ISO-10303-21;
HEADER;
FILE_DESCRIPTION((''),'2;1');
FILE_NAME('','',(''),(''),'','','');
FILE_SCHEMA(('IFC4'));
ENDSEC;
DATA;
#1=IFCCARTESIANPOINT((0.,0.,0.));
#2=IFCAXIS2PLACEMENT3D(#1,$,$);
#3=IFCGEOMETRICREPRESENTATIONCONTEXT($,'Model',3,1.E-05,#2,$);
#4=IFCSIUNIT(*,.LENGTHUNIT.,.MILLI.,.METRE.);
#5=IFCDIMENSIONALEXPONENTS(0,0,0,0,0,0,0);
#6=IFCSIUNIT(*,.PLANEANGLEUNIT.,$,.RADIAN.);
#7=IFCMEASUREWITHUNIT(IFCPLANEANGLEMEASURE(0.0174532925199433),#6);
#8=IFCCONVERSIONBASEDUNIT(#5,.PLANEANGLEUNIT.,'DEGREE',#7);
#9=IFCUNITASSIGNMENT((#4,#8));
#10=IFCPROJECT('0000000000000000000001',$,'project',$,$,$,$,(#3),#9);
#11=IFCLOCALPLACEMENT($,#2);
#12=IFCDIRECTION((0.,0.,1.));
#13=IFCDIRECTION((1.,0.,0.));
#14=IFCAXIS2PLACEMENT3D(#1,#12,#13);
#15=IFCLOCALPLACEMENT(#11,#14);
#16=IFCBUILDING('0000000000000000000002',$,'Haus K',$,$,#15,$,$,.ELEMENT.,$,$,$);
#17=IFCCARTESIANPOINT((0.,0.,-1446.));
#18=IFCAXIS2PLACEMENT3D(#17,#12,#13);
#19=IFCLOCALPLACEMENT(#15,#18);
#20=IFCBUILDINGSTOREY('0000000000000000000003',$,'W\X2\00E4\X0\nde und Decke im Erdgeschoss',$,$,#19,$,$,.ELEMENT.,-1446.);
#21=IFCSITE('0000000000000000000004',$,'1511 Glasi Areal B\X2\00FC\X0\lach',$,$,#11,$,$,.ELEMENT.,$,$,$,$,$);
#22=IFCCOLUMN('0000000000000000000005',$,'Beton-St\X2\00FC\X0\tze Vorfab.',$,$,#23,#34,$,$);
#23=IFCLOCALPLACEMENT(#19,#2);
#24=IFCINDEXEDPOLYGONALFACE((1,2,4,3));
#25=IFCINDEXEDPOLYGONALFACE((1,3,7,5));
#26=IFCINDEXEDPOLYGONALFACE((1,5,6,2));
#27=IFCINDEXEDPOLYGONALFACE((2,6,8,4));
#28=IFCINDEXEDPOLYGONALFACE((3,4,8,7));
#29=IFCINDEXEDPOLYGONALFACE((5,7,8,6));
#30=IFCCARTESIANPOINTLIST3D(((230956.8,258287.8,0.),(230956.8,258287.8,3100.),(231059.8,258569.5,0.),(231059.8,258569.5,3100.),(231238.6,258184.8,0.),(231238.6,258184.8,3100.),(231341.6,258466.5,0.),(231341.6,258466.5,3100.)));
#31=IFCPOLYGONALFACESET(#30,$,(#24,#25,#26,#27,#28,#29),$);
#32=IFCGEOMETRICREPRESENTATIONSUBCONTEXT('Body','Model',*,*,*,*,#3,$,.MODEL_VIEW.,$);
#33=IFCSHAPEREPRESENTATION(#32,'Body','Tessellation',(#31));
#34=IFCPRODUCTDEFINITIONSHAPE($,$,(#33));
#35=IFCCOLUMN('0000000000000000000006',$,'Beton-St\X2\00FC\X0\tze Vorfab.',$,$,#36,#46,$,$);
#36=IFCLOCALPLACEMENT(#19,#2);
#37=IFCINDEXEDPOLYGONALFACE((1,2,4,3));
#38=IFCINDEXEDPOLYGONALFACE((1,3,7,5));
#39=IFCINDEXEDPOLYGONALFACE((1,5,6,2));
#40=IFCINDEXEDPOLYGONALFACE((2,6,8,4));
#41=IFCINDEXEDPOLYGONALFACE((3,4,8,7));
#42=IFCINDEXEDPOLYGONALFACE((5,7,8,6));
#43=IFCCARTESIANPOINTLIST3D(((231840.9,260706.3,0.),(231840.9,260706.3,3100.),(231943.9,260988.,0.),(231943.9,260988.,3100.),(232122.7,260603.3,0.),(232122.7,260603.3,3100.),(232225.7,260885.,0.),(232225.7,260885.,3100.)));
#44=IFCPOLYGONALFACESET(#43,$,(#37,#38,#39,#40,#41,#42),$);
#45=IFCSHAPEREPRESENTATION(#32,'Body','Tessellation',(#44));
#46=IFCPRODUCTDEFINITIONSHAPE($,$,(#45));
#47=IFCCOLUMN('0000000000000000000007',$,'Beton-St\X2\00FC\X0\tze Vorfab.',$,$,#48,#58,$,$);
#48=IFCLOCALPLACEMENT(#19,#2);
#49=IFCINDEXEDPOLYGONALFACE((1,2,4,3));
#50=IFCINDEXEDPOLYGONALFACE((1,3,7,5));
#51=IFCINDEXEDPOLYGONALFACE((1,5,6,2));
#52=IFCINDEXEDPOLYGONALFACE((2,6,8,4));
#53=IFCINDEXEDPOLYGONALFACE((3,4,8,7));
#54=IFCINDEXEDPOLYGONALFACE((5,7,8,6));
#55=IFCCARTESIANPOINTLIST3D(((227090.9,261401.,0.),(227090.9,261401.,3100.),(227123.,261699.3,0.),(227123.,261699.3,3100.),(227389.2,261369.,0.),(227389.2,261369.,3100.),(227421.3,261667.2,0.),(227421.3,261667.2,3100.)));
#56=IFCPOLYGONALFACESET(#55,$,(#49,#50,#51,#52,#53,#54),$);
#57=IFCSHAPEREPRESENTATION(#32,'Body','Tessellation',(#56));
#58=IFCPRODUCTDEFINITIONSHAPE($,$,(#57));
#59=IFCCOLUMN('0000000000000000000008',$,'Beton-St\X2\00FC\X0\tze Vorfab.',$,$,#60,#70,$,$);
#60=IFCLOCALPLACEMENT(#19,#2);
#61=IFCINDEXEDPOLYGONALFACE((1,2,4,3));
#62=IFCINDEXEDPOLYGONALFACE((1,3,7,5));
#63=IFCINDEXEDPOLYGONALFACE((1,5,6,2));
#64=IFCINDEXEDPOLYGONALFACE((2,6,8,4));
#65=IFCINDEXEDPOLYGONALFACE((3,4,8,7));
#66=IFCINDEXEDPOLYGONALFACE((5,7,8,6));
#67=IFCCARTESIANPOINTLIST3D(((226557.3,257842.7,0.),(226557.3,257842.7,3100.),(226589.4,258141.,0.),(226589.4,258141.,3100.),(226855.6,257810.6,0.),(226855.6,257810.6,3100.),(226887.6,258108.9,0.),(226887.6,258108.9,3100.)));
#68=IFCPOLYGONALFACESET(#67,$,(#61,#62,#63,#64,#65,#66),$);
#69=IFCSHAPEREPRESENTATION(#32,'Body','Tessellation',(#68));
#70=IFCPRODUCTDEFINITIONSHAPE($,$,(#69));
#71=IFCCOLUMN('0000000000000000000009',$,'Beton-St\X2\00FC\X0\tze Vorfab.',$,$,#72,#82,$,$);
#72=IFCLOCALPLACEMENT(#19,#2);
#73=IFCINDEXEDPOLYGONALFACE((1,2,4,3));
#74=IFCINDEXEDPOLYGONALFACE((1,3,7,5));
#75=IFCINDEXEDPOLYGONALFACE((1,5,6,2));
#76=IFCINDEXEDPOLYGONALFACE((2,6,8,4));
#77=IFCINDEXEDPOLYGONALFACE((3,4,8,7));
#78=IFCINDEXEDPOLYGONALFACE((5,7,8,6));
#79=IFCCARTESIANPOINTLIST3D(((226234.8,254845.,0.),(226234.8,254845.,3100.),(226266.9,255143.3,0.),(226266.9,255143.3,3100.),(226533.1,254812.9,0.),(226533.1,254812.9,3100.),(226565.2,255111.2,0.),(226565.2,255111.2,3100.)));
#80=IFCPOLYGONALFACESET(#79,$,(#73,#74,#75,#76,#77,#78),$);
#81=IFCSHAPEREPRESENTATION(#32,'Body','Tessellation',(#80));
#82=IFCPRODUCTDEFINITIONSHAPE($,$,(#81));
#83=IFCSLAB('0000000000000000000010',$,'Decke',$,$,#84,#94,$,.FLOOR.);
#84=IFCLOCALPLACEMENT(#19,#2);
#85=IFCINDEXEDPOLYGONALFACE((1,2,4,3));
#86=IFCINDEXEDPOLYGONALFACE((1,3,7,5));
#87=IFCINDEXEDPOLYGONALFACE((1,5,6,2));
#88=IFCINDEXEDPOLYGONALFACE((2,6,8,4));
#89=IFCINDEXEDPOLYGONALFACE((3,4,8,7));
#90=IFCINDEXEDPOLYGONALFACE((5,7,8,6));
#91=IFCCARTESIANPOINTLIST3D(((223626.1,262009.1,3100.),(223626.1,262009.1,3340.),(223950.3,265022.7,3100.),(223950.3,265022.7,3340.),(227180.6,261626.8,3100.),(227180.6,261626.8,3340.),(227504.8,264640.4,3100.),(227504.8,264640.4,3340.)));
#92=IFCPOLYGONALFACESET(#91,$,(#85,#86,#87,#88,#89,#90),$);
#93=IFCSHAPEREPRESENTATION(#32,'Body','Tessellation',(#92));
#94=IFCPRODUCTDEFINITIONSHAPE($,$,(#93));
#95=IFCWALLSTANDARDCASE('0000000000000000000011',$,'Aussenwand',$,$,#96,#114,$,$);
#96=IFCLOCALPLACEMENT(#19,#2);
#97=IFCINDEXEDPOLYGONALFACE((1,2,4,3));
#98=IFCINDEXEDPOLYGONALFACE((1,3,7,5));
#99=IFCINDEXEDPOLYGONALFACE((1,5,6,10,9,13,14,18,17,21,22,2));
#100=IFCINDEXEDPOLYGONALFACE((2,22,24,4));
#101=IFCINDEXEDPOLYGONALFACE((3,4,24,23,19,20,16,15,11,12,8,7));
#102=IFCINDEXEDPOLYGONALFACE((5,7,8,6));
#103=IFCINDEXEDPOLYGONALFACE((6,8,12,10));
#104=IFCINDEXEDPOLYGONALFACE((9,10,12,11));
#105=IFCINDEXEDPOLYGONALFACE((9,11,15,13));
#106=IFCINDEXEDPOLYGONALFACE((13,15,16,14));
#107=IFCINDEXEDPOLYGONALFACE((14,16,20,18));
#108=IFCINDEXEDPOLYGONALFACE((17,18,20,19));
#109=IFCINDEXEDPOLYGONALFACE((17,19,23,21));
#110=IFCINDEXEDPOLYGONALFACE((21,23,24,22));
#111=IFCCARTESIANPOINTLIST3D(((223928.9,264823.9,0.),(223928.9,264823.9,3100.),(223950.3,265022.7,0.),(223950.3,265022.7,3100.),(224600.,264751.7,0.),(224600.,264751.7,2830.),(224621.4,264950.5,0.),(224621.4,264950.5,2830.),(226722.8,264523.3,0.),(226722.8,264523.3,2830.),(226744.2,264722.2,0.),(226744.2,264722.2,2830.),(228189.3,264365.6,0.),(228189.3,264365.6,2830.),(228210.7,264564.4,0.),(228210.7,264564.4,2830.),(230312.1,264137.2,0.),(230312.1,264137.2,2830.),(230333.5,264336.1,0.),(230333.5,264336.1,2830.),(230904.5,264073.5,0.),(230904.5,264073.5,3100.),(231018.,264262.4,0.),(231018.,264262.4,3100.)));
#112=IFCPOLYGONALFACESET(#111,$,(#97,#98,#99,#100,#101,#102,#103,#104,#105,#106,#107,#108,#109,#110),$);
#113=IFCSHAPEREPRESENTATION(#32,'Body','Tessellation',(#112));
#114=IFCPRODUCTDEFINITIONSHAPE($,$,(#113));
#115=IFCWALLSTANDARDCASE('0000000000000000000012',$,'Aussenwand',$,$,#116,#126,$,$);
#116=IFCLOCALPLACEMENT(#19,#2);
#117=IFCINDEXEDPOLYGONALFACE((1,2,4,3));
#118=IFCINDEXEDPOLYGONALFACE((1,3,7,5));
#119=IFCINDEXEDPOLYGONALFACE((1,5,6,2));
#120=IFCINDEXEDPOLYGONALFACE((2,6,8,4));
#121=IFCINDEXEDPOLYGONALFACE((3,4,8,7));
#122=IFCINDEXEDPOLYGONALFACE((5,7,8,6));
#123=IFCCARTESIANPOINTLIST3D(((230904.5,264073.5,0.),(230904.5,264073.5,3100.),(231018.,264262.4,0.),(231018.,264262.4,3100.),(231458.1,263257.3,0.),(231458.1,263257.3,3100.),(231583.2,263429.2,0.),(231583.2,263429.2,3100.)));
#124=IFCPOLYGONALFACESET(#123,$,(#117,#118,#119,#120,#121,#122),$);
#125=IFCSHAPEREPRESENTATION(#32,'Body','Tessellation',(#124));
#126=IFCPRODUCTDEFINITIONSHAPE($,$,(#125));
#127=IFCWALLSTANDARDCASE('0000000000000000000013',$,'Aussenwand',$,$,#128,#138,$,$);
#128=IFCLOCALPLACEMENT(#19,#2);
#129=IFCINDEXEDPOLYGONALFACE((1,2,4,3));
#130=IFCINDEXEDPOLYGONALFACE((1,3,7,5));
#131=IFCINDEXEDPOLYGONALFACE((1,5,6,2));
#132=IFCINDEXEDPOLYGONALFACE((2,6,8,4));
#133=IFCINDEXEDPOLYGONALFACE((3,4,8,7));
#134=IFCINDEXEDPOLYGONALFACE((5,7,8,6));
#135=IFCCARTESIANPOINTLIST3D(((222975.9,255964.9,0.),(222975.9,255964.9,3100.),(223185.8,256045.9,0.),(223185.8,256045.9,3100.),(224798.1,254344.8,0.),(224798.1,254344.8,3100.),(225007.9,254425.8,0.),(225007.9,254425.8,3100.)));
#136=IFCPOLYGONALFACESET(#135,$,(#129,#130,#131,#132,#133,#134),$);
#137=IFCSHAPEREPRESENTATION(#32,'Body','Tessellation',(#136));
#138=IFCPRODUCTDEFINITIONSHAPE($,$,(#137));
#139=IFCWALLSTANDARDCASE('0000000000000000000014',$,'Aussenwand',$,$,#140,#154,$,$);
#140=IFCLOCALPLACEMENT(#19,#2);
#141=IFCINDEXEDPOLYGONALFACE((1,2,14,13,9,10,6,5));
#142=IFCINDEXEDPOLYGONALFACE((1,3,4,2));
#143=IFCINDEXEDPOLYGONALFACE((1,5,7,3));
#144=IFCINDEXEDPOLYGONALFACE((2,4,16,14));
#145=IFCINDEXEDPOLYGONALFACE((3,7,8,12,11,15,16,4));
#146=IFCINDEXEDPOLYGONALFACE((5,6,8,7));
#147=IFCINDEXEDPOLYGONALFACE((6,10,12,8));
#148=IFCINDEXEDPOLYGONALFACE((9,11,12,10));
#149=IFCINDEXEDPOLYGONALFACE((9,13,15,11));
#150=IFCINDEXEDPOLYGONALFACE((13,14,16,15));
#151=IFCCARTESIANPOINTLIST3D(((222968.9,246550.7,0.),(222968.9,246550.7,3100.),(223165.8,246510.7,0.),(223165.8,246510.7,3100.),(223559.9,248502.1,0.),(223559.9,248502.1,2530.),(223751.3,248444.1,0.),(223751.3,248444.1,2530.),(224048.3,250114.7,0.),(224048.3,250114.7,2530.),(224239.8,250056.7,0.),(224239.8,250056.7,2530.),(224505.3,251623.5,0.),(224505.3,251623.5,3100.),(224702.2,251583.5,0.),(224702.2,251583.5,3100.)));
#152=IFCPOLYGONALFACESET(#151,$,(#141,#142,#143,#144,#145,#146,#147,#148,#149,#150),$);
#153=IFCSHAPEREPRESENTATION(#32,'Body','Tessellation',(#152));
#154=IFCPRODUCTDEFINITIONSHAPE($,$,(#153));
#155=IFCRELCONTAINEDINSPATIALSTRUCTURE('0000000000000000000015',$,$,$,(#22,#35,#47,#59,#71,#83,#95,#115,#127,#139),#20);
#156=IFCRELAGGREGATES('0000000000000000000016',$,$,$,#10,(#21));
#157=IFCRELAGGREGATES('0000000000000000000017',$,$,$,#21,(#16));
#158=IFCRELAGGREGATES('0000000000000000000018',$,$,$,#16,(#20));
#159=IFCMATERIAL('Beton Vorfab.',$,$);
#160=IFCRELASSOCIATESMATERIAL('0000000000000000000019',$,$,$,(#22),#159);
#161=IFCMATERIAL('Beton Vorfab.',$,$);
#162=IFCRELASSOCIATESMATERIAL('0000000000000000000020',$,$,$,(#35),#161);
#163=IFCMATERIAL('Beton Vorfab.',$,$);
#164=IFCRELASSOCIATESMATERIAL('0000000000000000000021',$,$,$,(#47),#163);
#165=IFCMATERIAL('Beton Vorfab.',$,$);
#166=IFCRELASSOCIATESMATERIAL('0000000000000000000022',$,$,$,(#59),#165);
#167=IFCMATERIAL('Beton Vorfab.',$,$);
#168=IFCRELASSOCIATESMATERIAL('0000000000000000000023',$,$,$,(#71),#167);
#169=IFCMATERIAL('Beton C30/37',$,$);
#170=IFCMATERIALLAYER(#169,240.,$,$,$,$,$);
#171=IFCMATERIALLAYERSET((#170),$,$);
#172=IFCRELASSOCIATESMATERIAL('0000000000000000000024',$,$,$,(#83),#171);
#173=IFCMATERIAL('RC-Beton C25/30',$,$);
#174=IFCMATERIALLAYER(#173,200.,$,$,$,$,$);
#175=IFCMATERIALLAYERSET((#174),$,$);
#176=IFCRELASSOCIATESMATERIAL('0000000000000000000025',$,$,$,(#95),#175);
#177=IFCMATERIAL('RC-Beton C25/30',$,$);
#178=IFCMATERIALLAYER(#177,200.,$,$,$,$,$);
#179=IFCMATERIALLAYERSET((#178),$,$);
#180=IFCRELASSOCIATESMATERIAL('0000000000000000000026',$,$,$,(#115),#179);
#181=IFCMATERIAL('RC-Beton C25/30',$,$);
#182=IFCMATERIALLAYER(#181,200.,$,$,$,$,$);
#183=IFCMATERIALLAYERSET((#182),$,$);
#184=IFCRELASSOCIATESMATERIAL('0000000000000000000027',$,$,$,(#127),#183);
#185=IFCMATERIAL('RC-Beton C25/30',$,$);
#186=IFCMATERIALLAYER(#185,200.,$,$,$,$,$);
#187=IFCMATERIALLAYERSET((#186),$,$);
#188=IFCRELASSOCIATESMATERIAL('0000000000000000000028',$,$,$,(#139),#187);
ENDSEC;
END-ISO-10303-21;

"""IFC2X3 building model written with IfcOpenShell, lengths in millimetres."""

from ifc_helpers import new_model, entity, si_unit, converted_unit, frame, frame_2d, origin, origin_with_axes, place, context, subcontext, project, spatial, polyline, rectangle, outline, extrude, material, layer, layer_set, layer_usage, element, save


model = new_model("IFC2X3")

# Units and contexts
model_context = context("Model", 3, precision=1e-05, world=origin())
body_context = subcontext(model_context, "Body", "Model", "MODEL_VIEW")
ifc_project = project(units=[si_unit("LENGTHUNIT", "METRE", prefix="MILLI"), converted_unit("PLANEANGLEUNIT", "DEGREE", entity("IfcPlaneAngleMeasure", 0.0174532925199433), si_unit("PLANEANGLEUNIT", "RADIAN"), dimensions=[0, 0, 0, 0, 0, 0, 0])], contexts=[model_context])

# Site, building, storey
site_placement = place(None, origin())
site = spatial("IfcSite", under=ifc_project, at=site_placement, Name="1511 Glasi Areal Bülach", CompositionType="ELEMENT")
building_placement = place(site_placement, origin_with_axes())
building = spatial("IfcBuilding", under=site, at=building_placement, Name="Haus K", CompositionType="ELEMENT")
storey_placement = place(building_placement, frame((0.0, 0.0, -1446.0), z_axis=(0.0, 0.0, 1.0), x_axis=(1.0, 0.0, 0.0)))
storey = spatial("IfcBuildingStorey", under=building, at=storey_placement, Name="Wände und Decke im Erdgeschoss", CompositionType="ELEMENT", Elevation=-1446.0)

# Columns
ifc_material_1 = material(Name="Beton Vorfab.")
column_1_placement = place(storey_placement, frame((230956.8, 258287.8, 0.0), z_axis=(0.0, 0.0, 1.0), x_axis=(1.0, 0.0, 0.0)))
element("IfcColumn", 1, at=column_1_placement, inside=storey, material=ifc_material_1, Name="Beton-Stütze Vorfab.", context=body_context, shape_type="SweptSolid", body=[
    extrude(rectangle(XDim=300.0, YDim=300.0, at=frame_2d((192.4, 89.4), x_axis=(0.939214, -0.343332))), origin_with_axes(), (0.0, 0.0, 1.0), 3100.0),
])
ifc_material_2 = material(Name="Beton Vorfab.")
column_2_placement = place(storey_placement, frame((231840.9, 260706.3, 0.0), z_axis=(0.0, 0.0, 1.0), x_axis=(1.0, 0.0, 0.0)))
element("IfcColumn", 2, at=column_2_placement, inside=storey, material=ifc_material_2, Name="Beton-Stütze Vorfab.", context=body_context, shape_type="SweptSolid", body=[
    extrude(rectangle(XDim=300.0, YDim=300.0, at=frame_2d((192.4, 89.4), x_axis=(0.939214, -0.343332))), origin_with_axes(), (0.0, 0.0, 1.0), 3100.0),
])
ifc_material_3 = material(Name="Beton Vorfab.")
column_3_placement = place(storey_placement, frame((227090.9, 261401.0, 0.0), z_axis=(0.0, 0.0, 1.0), x_axis=(1.0, 0.0, 0.0)))
element("IfcColumn", 3, at=column_3_placement, inside=storey, material=ifc_material_3, Name="Beton-Stütze Vorfab.", context=body_context, shape_type="SweptSolid", body=[
    extrude(rectangle(XDim=300.0, YDim=300.0, at=frame_2d((165.2, 133.1), x_axis=(0.994264, -0.106958))), origin_with_axes(), (0.0, 0.0, 1.0), 3100.0),
])
ifc_material_4 = material(Name="Beton Vorfab.")
column_4_placement = place(storey_placement, frame((226557.3, 257842.7, 0.0), z_axis=(0.0, 0.0, 1.0), x_axis=(1.0, 0.0, 0.0)))
element("IfcColumn", 4, at=column_4_placement, inside=storey, material=ifc_material_4, Name="Beton-Stütze Vorfab.", context=body_context, shape_type="SweptSolid", body=[
    extrude(rectangle(XDim=300.0, YDim=300.0, at=frame_2d((165.2, 133.1), x_axis=(0.994264, -0.106958))), origin_with_axes(), (0.0, 0.0, 1.0), 3100.0),
])
ifc_material_5 = material(Name="Beton Vorfab.")
column_5_placement = place(storey_placement, frame((226234.8, 254845.0, 0.0), z_axis=(0.0, 0.0, 1.0), x_axis=(1.0, 0.0, 0.0)))
element("IfcColumn", 5, at=column_5_placement, inside=storey, material=ifc_material_5, Name="Beton-Stütze Vorfab.", context=body_context, shape_type="SweptSolid", body=[
    extrude(rectangle(XDim=300.0, YDim=300.0, at=frame_2d((165.2, 133.1), x_axis=(0.994264, -0.106958))), origin_with_axes(), (0.0, 0.0, 1.0), 3100.0),
])

# Slab
ifc_material_6 = material(Name="Beton C30/37")
ifc_layer_1 = layer(ifc_material_6, 240.0)
ifc_layer_set_1 = layer_set([ifc_layer_1])
ifc_layer_usage_1 = layer_usage(ifc_layer_set_1, "AXIS3", "POSITIVE", 0.0)
slab_placement = place(storey_placement, frame((223950.3, 265022.7, 3100.0), z_axis=(0.0, 0.0, 1.0), x_axis=(1.0, 0.0, 0.0)))
element("IfcSlab", 6, at=slab_placement, inside=storey, material=ifc_layer_usage_1, Name="Decke", PredefinedType="FLOOR", context=body_context, shape_type="SweptSolid", body=[
    extrude(rectangle(XDim=3031.0, YDim=3575.0, at=frame_2d((1615.2, -1698.0), x_axis=(-0.106958, -0.994264))), origin_with_axes(), (0.0, 0.0, 1.0), 240.0),
])

# Wall, openings
ifc_material_7 = material(Name="RC-Beton C25/30")
ifc_layer_2 = layer(ifc_material_7, 200.0)
ifc_layer_set_2 = layer_set([ifc_layer_2])
ifc_layer_usage_2 = layer_usage(ifc_layer_set_2, "AXIS2", "POSITIVE", 0.0)
wall_1_placement = place(storey_placement, frame((231018.0, 264262.4, 0.0), z_axis=(0.0, 0.0, 1.0), x_axis=(-0.994264, 0.106958, 0.0)))
wall_1 = element("IfcWallStandardCase", 7, at=wall_1_placement, inside=storey, material=ifc_layer_usage_2, Name="Aussenwand", context=body_context, shape_type="SweptSolid", body=[
    extrude(outline(polyline([(0.0, 0.0), (7108.5, 0.0), (7108.5, 200.0), (92.6, 200.0), (0.0, 0.0)])), origin_with_axes(), (0.0, 0.0, 1.0), 3100.0),
])
opening_1_placement = place(wall_1_placement, frame((4298.5, 0.0, 0.0), z_axis=(0.0, 1.0, 0.0), x_axis=(0.0, 0.0, 1.0)))
element("IfcOpeningElement", 8, at=opening_1_placement, cuts=wall_1, ObjectType="Opening", context=body_context, shape_type="SweptSolid", body=[
    extrude(rectangle(XDim=2830.0, YDim=2135.0, at=frame_2d((1415.0, 1067.5), x_axis=(1.0, 0.0))), origin_with_axes(), (0.0, 0.0, 1.0), 200.0),
])
opening_2_placement = place(wall_1_placement, frame((688.5, 0.0, 0.0), z_axis=(0.0, 1.0, 0.0), x_axis=(0.0, 0.0, 1.0)))
element("IfcOpeningElement", 9, at=opening_2_placement, cuts=wall_1, ObjectType="Opening", context=body_context, shape_type="SweptSolid", body=[
    extrude(rectangle(XDim=2830.0, YDim=2135.0, at=frame_2d((1415.0, 1067.5), x_axis=(1.0, 0.0))), origin_with_axes(), (0.0, 0.0, 1.0), 200.0),
])

# Walls
ifc_material_8 = material(Name="RC-Beton C25/30")
ifc_layer_3 = layer(ifc_material_8, 200.0)
ifc_layer_set_3 = layer_set([ifc_layer_3])
ifc_layer_usage_3 = layer_usage(ifc_layer_set_3, "AXIS2", "POSITIVE", 0.0)
wall_2_placement = place(storey_placement, frame((231583.2, 263429.2, 0.0), z_axis=(0.0, 0.0, 1.0), x_axis=(-0.561361, 0.827571, 0.0)))
element("IfcWallStandardCase", 10, at=wall_2_placement, inside=storey, material=ifc_layer_usage_3, Name="Aussenwand", context=body_context, shape_type="SweptSolid", body=[
    extrude(outline(polyline([(0.0, 0.0), (1006.9, 0.0), (914.2, 200.0), (-72.0, 200.0), (0.0, 0.0)])), origin_with_axes(), (0.0, 0.0, 1.0), 3100.0),
])
ifc_material_9 = material(Name="RC-Beton C25/30")
ifc_layer_4 = layer(ifc_material_9, 200.0)
ifc_layer_set_4 = layer_set([ifc_layer_4])
ifc_layer_usage_4 = layer_usage(ifc_layer_set_4, "AXIS2", "POSITIVE", 0.0)
wall_3_placement = place(storey_placement, frame((222975.9, 255964.9, 0.0), z_axis=(0.0, 0.0, 1.0), x_axis=(0.747334, -0.664448, 0.0)))
element("IfcWallStandardCase", 11, at=wall_3_placement, inside=storey, material=ifc_layer_usage_4, Name="Aussenwand", context=body_context, shape_type="SweptSolid", body=[
    extrude(outline(polyline([(0.0, 0.0), (2438.2, 0.0), (2541.2, 200.0), (103.0, 200.0), (0.0, 0.0)])), origin_with_axes(), (0.0, 0.0, 1.0), 3100.0),
])

# Wall, opening
ifc_material_10 = material(Name="RC-Beton C25/30")
ifc_layer_5 = layer(ifc_material_10, 200.0)
ifc_layer_set_5 = layer_set([ifc_layer_5])
ifc_layer_usage_5 = layer_usage(ifc_layer_set_5, "AXIS2", "POSITIVE", 0.0)
wall_4_placement = place(storey_placement, frame((224505.3, 251623.5, 0.0), z_axis=(0.0, 0.0, 1.0), x_axis=(-0.289867, -0.957067, 0.0)))
wall_4 = element("IfcWallStandardCase", 12, at=wall_4_placement, inside=storey, material=ifc_layer_usage_5, Name="Aussenwand", context=body_context, shape_type="SweptSolid", body=[
    extrude(outline(polyline([(0.0, 0.0), (5300.3, 0.0), (5281.6, 200.0), (-18.7, 200.0), (0.0, 0.0)])), origin_with_axes(), (0.0, 0.0, 1.0), 3100.0),
])
opening_3_placement = place(wall_4_placement, frame((1576.5, 0.0, 0.0), z_axis=(0.0, 1.0, 0.0), x_axis=(0.0, 0.0, 1.0)))
element("IfcOpeningElement", 13, at=opening_3_placement, cuts=wall_4, ObjectType="Opening", context=body_context, shape_type="SweptSolid", body=[
    extrude(rectangle(XDim=2530.0, YDim=1685.0, at=frame_2d((1265.0, 842.5), x_axis=(1.0, 0.0))), origin_with_axes(), (0.0, 0.0, 1.0), 200.0),
])

save(model, "model.ifc")
